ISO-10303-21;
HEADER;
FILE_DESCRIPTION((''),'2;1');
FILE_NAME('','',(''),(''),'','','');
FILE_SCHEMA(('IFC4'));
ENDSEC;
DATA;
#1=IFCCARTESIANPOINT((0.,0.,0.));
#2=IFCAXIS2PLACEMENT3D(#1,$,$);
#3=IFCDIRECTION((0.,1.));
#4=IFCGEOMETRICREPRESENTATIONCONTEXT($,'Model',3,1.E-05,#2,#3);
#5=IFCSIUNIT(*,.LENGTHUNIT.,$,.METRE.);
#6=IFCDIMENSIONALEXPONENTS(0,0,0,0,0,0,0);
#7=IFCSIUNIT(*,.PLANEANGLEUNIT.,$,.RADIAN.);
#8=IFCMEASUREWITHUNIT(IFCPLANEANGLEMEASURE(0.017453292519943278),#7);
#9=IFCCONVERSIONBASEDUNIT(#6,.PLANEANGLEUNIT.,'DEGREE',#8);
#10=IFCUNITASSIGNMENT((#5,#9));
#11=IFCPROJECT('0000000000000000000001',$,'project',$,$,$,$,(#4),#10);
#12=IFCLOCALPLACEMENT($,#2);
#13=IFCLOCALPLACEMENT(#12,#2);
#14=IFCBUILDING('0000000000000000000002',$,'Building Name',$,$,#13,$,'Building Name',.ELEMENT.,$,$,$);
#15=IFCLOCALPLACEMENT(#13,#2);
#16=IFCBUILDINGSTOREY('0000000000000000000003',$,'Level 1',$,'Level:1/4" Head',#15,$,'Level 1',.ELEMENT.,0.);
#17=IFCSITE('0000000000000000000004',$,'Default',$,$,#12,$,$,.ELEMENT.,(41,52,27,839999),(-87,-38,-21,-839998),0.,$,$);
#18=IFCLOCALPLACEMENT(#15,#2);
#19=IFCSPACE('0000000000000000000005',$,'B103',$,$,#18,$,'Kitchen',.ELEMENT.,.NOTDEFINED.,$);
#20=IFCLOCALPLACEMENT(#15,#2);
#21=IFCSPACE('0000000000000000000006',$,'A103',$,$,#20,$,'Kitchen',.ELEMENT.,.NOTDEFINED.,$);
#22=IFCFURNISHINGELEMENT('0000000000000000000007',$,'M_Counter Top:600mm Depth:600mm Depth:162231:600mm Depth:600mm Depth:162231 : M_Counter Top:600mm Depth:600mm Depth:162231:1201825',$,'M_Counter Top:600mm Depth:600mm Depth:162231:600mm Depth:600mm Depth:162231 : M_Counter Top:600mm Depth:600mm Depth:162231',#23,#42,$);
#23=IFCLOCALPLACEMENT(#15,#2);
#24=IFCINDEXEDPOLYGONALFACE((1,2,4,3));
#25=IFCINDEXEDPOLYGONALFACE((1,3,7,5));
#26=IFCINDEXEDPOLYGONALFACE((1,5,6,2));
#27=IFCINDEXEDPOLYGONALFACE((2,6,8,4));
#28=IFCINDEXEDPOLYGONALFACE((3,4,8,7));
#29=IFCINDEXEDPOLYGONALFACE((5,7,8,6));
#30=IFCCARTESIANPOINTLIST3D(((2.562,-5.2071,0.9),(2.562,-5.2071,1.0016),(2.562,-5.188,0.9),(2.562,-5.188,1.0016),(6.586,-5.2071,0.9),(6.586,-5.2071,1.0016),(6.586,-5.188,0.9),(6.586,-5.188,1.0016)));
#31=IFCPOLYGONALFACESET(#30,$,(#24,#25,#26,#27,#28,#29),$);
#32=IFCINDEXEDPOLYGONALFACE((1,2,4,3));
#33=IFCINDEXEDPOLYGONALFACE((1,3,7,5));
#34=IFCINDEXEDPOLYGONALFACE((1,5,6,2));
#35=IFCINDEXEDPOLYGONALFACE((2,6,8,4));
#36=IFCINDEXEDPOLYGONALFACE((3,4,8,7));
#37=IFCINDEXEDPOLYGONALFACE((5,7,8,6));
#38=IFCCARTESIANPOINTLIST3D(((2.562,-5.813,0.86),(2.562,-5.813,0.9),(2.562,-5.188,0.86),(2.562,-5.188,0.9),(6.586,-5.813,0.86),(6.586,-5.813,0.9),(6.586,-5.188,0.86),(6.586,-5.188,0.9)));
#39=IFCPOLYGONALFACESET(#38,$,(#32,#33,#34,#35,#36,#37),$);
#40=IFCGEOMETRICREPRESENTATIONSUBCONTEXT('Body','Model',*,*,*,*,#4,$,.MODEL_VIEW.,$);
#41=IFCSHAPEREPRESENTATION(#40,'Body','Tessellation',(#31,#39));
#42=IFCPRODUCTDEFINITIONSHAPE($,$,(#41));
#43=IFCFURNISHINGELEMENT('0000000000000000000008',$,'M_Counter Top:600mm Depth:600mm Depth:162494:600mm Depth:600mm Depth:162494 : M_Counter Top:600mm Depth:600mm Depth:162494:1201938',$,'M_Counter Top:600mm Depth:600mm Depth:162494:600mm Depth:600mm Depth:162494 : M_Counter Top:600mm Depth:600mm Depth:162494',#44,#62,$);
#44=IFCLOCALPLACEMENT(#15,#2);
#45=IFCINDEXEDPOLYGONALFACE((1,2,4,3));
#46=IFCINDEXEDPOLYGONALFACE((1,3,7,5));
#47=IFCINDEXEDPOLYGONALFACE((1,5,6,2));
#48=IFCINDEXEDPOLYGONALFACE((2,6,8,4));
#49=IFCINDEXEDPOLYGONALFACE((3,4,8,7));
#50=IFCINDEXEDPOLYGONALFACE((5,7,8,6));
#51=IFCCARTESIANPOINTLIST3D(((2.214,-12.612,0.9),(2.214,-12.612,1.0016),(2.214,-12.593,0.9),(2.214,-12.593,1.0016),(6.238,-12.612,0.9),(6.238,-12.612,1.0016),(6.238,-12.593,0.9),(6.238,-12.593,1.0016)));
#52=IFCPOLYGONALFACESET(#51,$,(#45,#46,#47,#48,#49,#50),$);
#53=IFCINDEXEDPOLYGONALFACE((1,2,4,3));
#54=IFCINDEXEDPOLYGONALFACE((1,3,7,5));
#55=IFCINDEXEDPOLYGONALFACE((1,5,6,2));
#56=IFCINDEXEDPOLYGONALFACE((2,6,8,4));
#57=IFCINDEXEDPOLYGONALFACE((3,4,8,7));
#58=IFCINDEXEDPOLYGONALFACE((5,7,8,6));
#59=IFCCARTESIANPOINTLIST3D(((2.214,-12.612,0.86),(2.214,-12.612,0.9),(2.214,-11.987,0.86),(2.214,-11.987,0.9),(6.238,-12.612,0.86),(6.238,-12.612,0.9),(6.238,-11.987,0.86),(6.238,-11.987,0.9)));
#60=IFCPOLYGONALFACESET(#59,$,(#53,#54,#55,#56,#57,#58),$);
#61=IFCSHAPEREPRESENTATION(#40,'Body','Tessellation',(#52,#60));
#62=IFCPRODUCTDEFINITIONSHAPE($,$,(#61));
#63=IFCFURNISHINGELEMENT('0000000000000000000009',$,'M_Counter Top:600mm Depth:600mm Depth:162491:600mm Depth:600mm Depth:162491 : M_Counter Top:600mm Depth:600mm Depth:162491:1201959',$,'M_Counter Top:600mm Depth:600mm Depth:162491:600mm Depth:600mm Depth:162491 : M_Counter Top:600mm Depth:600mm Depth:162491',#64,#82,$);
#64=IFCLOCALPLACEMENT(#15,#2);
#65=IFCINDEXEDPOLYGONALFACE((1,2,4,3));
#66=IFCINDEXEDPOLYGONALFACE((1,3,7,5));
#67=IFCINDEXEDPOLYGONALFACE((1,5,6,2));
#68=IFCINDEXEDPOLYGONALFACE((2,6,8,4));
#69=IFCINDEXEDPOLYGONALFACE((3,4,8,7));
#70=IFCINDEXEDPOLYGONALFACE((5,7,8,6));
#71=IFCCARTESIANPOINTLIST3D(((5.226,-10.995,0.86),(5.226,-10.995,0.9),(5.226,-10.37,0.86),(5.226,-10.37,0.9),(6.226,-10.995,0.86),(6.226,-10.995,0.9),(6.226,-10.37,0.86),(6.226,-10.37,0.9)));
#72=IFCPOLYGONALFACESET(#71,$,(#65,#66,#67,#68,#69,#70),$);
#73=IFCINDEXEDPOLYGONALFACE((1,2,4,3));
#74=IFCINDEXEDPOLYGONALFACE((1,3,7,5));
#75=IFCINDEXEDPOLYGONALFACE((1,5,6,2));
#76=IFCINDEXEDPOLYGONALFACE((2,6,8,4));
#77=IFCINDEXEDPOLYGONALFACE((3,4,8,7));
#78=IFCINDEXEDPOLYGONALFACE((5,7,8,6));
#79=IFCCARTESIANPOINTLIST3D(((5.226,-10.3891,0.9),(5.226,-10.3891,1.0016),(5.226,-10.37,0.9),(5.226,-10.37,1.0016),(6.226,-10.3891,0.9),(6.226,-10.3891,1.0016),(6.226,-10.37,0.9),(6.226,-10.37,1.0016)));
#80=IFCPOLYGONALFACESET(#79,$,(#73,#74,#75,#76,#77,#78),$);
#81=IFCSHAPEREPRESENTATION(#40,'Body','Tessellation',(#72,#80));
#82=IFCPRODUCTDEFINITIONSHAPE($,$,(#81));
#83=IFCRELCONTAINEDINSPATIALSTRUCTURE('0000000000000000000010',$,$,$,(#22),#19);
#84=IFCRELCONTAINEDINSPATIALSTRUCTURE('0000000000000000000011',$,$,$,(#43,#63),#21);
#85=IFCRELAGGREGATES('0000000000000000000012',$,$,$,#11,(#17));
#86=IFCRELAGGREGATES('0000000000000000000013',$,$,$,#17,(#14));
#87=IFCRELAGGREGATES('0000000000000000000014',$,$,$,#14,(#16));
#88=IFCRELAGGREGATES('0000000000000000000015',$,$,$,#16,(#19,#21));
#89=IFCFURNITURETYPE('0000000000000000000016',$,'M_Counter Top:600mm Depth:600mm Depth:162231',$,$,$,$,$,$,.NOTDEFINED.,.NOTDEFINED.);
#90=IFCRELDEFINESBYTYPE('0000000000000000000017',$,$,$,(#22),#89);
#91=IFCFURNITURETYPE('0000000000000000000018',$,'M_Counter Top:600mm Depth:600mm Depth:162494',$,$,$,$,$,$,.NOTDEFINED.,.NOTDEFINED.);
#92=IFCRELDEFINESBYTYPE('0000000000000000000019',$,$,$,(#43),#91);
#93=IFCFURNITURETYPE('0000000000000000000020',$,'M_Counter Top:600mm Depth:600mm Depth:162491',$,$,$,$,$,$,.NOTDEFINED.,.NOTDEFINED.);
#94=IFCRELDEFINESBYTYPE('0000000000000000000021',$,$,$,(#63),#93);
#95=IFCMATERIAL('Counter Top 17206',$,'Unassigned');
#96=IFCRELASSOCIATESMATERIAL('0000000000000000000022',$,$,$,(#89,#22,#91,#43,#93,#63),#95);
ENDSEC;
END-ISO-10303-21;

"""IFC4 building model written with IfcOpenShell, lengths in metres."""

from ifc_helpers import new_model, entity, si_unit, converted_unit, direction, frame, origin, place, context, subcontext, project, spatial, indexed_curve, outline, extrude, source, transform, mapped, material, type_object, type_shapes, element, save


model = new_model("IFC4")

# Units and contexts
model_context = context("Model", 3, precision=1e-05, world=origin(), true_north=direction((0.0, 1.0)))
body_context = subcontext(model_context, "Body", "Model", "MODEL_VIEW")
ifc_project = project(units=[si_unit("LENGTHUNIT", "METRE"), converted_unit("PLANEANGLEUNIT", "DEGREE", entity("IfcPlaneAngleMeasure", 0.017453292519943278), si_unit("PLANEANGLEUNIT", "RADIAN"), dimensions=[0, 0, 0, 0, 0, 0, 0])], contexts=[model_context])

# Site, building, storey
site_placement = place(None, origin())
site = spatial("IfcSite", under=ifc_project, at=site_placement, Name="Default", CompositionType="ELEMENT", RefLatitude=(41, 52, 27, 839999), RefLongitude=(-87, -38, -21, -839998), RefElevation=0.0)
building_placement = place(site_placement, origin())
building = spatial("IfcBuilding", under=site, at=building_placement, Name="Building Name", LongName="Building Name", CompositionType="ELEMENT")
storey_placement = place(building_placement, origin())
storey = spatial("IfcBuildingStorey", under=building, at=storey_placement, Name="Level 1", ObjectType="Level:1/4\" Head", LongName="Level 1", CompositionType="ELEMENT", Elevation=0.0)

# Shared definitions
space_1_placement = place(storey_placement, origin())
space_1 = spatial("IfcSpace", under=storey, at=space_1_placement, Name="B103", LongName="Kitchen", CompositionType="ELEMENT", PredefinedType="NOTDEFINED")

# Furnishing element
ifc_material_1 = material(Name="Counter Top 17206", Category="Unassigned")
furniture_type_1 = type_object("IfcFurnitureType", Name="M_Counter Top:600mm Depth:600mm Depth:162231", AssemblyPlace="NOTDEFINED", PredefinedType="NOTDEFINED", material=ifc_material_1)
shared_shape_1 = source(origin(), body_context, "Body", "SweptSolid", [
    extrude(outline(indexed_curve([(-2.012, -0.0095), (2.012, -0.0095), (2.012, 0.0095), (-2.012, 0.0095), (-2.012, -0.0095)], self_intersect=False)), frame((4.574, -5.1975, 0.9)), (0.0, 0.0, 1.0), 0.1016),
    extrude(outline(indexed_curve([(-0.3125, -2.012), (0.3125, -2.012), (0.3125, 2.012), (-0.3125, 2.012), (-0.3125, -2.012)], self_intersect=False)), frame((4.574, -5.5005, 0.86), z_axis=(0.0, 0.0, 1.0), x_axis=(0.0, -1.0, 0.0)), (0.0, 0.0, 1.0), 0.04),
])
type_shapes(furniture_type_1, [shared_shape_1])
furnishing_1_placement = place(space_1_placement, origin())
element("IfcFurnishingElement", 1, at=furnishing_1_placement, inside=space_1, type_object=furniture_type_1, material=ifc_material_1, Name="M_Counter Top:600mm Depth:600mm Depth:162231:600mm Depth:600mm Depth:162231 : M_Counter Top:600mm Depth:600mm Depth:162231:1201825", ObjectType="M_Counter Top:600mm Depth:600mm Depth:162231:600mm Depth:600mm Depth:162231 : M_Counter Top:600mm Depth:600mm Depth:162231", context=body_context, shape_type="MappedRepresentation", body=[
    mapped(shared_shape_1, transform((0.0, 0.0, 0.0), scale=1.0)),
])

# Shared definitions
space_2_placement = place(storey_placement, origin())
space_2 = spatial("IfcSpace", under=storey, at=space_2_placement, Name="A103", LongName="Kitchen", CompositionType="ELEMENT", PredefinedType="NOTDEFINED")

# Furnishing elements
furniture_type_2 = type_object("IfcFurnitureType", Name="M_Counter Top:600mm Depth:600mm Depth:162494", AssemblyPlace="NOTDEFINED", PredefinedType="NOTDEFINED", material=ifc_material_1)
shared_shape_2 = source(origin(), body_context, "Body", "SweptSolid", [
    extrude(outline(indexed_curve([(-2.012, -0.0095), (2.012, -0.0095), (2.012, 0.0095), (-2.012, 0.0095), (-2.012, -0.0095)], self_intersect=False)), frame((4.226, -12.6025, 0.9), z_axis=(0.0, 0.0, 1.0), x_axis=(-1.0, 0.0, 0.0)), (0.0, 0.0, 1.0), 0.1016),
    extrude(outline(indexed_curve([(-0.3125, -2.012), (0.3125, -2.012), (0.3125, 2.012), (-0.3125, 2.012), (-0.3125, -2.012)], self_intersect=False)), frame((4.226, -12.2995, 0.86), z_axis=(0.0, 0.0, 1.0), x_axis=(0.0, 1.0, 0.0)), (0.0, 0.0, 1.0), 0.04),
])
type_shapes(furniture_type_2, [shared_shape_2])
furnishing_2_placement = place(space_2_placement, origin())
element("IfcFurnishingElement", 2, at=furnishing_2_placement, inside=space_2, type_object=furniture_type_2, material=ifc_material_1, Name="M_Counter Top:600mm Depth:600mm Depth:162494:600mm Depth:600mm Depth:162494 : M_Counter Top:600mm Depth:600mm Depth:162494:1201938", ObjectType="M_Counter Top:600mm Depth:600mm Depth:162494:600mm Depth:600mm Depth:162494 : M_Counter Top:600mm Depth:600mm Depth:162494", context=body_context, shape_type="MappedRepresentation", body=[
    mapped(shared_shape_2, transform((0.0, 0.0, 0.0), scale=1.0)),
])
furniture_type_3 = type_object("IfcFurnitureType", Name="M_Counter Top:600mm Depth:600mm Depth:162491", AssemblyPlace="NOTDEFINED", PredefinedType="NOTDEFINED", material=ifc_material_1)
shared_shape_3 = source(origin(), body_context, "Body", "SweptSolid", [
    extrude(outline(indexed_curve([(-0.3125, -0.5), (0.3125, -0.5), (0.3125, 0.5), (-0.3125, 0.5), (-0.3125, -0.5)], self_intersect=False)), frame((5.726, -10.6825, 0.86), z_axis=(0.0, 0.0, 1.0), x_axis=(0.0, -1.0, 0.0)), (0.0, 0.0, 1.0), 0.04),
    extrude(outline(indexed_curve([(-0.5, -0.0095), (0.5, -0.0095), (0.5, 0.0095), (-0.5, 0.0095), (-0.5, -0.0095)], self_intersect=False)), frame((5.726, -10.3795, 0.9)), (0.0, 0.0, 1.0), 0.1016),
])
type_shapes(furniture_type_3, [shared_shape_3])
furnishing_3_placement = place(space_2_placement, origin())
element("IfcFurnishingElement", 3, at=furnishing_3_placement, inside=space_2, type_object=furniture_type_3, material=ifc_material_1, Name="M_Counter Top:600mm Depth:600mm Depth:162491:600mm Depth:600mm Depth:162491 : M_Counter Top:600mm Depth:600mm Depth:162491:1201959", ObjectType="M_Counter Top:600mm Depth:600mm Depth:162491:600mm Depth:600mm Depth:162491 : M_Counter Top:600mm Depth:600mm Depth:162491", context=body_context, shape_type="MappedRepresentation", body=[
    mapped(shared_shape_3, transform((0.0, 0.0, 0.0), scale=1.0)),
])

save(model, "model.ifc")
